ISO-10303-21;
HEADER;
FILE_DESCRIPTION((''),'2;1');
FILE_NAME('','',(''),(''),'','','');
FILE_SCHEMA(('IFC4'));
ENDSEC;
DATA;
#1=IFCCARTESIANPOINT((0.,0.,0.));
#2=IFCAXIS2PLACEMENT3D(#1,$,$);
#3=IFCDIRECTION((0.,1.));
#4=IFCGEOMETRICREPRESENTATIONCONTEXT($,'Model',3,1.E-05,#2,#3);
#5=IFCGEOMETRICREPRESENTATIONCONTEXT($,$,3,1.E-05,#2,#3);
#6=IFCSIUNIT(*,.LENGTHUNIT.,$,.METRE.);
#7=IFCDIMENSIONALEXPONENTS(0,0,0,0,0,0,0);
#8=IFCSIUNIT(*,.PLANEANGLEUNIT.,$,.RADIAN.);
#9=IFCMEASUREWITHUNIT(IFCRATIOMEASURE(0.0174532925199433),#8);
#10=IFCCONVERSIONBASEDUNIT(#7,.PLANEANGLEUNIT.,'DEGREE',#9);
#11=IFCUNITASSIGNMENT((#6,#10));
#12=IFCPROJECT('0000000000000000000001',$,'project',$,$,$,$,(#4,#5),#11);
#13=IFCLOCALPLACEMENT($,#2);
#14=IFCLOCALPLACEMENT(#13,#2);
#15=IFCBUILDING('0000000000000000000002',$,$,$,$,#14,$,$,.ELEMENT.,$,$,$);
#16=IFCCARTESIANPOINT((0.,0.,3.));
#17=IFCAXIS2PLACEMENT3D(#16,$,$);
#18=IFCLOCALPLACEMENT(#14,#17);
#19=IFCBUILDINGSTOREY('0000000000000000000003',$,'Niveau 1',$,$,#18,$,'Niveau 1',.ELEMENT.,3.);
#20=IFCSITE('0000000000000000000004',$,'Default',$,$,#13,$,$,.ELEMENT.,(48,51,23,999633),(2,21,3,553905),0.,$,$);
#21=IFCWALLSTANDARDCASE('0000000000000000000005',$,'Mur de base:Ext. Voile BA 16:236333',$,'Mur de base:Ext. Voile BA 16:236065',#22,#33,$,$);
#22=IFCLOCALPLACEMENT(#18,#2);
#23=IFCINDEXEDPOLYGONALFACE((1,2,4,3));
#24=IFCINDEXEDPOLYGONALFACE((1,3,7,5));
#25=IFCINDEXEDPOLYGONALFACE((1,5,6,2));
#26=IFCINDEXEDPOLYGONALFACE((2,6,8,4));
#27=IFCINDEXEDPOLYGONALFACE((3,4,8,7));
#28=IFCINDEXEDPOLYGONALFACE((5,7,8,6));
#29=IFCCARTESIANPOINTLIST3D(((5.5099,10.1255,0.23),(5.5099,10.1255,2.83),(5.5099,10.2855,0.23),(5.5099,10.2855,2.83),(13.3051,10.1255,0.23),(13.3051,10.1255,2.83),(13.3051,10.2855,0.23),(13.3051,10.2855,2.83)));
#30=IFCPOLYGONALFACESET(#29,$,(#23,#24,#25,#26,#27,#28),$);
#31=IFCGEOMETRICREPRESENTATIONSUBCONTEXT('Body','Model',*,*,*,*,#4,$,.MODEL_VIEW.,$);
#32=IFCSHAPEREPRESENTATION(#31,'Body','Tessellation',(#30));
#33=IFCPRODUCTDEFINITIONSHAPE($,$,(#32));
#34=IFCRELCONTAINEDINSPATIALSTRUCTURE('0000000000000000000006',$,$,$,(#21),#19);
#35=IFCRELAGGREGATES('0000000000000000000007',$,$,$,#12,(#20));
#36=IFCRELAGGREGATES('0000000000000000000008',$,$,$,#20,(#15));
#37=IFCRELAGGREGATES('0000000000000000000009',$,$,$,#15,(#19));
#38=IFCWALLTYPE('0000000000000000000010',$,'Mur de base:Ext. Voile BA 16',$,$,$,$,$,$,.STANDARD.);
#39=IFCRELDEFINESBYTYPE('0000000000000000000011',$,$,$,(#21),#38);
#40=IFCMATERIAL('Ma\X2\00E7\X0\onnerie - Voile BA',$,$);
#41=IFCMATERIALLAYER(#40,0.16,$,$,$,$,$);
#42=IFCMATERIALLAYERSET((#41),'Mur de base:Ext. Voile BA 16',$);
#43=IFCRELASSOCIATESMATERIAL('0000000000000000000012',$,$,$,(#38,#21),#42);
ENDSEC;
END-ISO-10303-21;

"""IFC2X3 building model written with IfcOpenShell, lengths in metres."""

from ifc_helpers import new_model, entity, si_unit, converted_unit, direction, frame, frame_2d, origin, place, context, subcontext, project, spatial, rectangle, extrude, material, layer, layer_set, layer_usage, type_object, element, save


model = new_model("IFC2X3")

# Units and contexts
model_context = context("Model", 3, precision=1e-05, world=origin(), true_north=direction((0.0, 1.0)))
context_of_model = context(None, 3, precision=1e-05, world=origin(), true_north=direction((0.0, 1.0)))
body_context = subcontext(model_context, "Body", "Model", "MODEL_VIEW")
ifc_project = project(units=[si_unit("LENGTHUNIT", "METRE"), converted_unit("PLANEANGLEUNIT", "DEGREE", entity("IfcRatioMeasure", 0.0174532925199433), si_unit("PLANEANGLEUNIT", "RADIAN"), dimensions=[0, 0, 0, 0, 0, 0, 0])], contexts=[model_context, context_of_model])

# Site, building, storey
site_placement = place(None, origin())
site = spatial("IfcSite", under=ifc_project, at=site_placement, Name="Default", CompositionType="ELEMENT", RefLatitude=(48, 51, 23, 999633), RefLongitude=(2, 21, 3, 553905), RefElevation=0.0)
building_placement = place(site_placement, origin())
building = spatial("IfcBuilding", under=site, at=building_placement, CompositionType="ELEMENT")
storey_placement = place(building_placement, frame((0.0, 0.0, 3.0)))
storey = spatial("IfcBuildingStorey", under=building, at=storey_placement, Name="Niveau 1", LongName="Niveau 1", CompositionType="ELEMENT", Elevation=3.0)

# Shared definitions
ifc_material_1 = material(Name="Maçonnerie - Voile BA")

# Shared definitions
ifc_layer_1 = layer(ifc_material_1, 0.16)
ifc_layer_set_1 = layer_set([ifc_layer_1], Name="Mur de base:Ext. Voile BA 16")
wall_type_1 = type_object("IfcWallType", Name="Mur de base:Ext. Voile BA 16", PredefinedType="STANDARD", material=ifc_layer_set_1)

# Wall
ifc_layer_usage_1 = layer_usage(ifc_layer_set_1, "AXIS2", "NEGATIVE", 0.08)
wall_1_placement = place(storey_placement, frame((5.5099, 10.2055, 0.23)))
element("IfcWallStandardCase", 1, at=wall_1_placement, inside=storey, type_object=wall_type_1, material=ifc_layer_usage_1, Name="Mur de base:Ext. Voile BA 16:236333", ObjectType="Mur de base:Ext. Voile BA 16:236065", context=body_context, shape_type="SweptSolid", body=[
    extrude(rectangle(XDim=7.7952, YDim=0.16, at=frame_2d((3.8976, 0.0), x_axis=(-1.0, 0.0))), origin(), (0.0, 0.0, 1.0), 2.6),
])

save(model, "model.ifc")
